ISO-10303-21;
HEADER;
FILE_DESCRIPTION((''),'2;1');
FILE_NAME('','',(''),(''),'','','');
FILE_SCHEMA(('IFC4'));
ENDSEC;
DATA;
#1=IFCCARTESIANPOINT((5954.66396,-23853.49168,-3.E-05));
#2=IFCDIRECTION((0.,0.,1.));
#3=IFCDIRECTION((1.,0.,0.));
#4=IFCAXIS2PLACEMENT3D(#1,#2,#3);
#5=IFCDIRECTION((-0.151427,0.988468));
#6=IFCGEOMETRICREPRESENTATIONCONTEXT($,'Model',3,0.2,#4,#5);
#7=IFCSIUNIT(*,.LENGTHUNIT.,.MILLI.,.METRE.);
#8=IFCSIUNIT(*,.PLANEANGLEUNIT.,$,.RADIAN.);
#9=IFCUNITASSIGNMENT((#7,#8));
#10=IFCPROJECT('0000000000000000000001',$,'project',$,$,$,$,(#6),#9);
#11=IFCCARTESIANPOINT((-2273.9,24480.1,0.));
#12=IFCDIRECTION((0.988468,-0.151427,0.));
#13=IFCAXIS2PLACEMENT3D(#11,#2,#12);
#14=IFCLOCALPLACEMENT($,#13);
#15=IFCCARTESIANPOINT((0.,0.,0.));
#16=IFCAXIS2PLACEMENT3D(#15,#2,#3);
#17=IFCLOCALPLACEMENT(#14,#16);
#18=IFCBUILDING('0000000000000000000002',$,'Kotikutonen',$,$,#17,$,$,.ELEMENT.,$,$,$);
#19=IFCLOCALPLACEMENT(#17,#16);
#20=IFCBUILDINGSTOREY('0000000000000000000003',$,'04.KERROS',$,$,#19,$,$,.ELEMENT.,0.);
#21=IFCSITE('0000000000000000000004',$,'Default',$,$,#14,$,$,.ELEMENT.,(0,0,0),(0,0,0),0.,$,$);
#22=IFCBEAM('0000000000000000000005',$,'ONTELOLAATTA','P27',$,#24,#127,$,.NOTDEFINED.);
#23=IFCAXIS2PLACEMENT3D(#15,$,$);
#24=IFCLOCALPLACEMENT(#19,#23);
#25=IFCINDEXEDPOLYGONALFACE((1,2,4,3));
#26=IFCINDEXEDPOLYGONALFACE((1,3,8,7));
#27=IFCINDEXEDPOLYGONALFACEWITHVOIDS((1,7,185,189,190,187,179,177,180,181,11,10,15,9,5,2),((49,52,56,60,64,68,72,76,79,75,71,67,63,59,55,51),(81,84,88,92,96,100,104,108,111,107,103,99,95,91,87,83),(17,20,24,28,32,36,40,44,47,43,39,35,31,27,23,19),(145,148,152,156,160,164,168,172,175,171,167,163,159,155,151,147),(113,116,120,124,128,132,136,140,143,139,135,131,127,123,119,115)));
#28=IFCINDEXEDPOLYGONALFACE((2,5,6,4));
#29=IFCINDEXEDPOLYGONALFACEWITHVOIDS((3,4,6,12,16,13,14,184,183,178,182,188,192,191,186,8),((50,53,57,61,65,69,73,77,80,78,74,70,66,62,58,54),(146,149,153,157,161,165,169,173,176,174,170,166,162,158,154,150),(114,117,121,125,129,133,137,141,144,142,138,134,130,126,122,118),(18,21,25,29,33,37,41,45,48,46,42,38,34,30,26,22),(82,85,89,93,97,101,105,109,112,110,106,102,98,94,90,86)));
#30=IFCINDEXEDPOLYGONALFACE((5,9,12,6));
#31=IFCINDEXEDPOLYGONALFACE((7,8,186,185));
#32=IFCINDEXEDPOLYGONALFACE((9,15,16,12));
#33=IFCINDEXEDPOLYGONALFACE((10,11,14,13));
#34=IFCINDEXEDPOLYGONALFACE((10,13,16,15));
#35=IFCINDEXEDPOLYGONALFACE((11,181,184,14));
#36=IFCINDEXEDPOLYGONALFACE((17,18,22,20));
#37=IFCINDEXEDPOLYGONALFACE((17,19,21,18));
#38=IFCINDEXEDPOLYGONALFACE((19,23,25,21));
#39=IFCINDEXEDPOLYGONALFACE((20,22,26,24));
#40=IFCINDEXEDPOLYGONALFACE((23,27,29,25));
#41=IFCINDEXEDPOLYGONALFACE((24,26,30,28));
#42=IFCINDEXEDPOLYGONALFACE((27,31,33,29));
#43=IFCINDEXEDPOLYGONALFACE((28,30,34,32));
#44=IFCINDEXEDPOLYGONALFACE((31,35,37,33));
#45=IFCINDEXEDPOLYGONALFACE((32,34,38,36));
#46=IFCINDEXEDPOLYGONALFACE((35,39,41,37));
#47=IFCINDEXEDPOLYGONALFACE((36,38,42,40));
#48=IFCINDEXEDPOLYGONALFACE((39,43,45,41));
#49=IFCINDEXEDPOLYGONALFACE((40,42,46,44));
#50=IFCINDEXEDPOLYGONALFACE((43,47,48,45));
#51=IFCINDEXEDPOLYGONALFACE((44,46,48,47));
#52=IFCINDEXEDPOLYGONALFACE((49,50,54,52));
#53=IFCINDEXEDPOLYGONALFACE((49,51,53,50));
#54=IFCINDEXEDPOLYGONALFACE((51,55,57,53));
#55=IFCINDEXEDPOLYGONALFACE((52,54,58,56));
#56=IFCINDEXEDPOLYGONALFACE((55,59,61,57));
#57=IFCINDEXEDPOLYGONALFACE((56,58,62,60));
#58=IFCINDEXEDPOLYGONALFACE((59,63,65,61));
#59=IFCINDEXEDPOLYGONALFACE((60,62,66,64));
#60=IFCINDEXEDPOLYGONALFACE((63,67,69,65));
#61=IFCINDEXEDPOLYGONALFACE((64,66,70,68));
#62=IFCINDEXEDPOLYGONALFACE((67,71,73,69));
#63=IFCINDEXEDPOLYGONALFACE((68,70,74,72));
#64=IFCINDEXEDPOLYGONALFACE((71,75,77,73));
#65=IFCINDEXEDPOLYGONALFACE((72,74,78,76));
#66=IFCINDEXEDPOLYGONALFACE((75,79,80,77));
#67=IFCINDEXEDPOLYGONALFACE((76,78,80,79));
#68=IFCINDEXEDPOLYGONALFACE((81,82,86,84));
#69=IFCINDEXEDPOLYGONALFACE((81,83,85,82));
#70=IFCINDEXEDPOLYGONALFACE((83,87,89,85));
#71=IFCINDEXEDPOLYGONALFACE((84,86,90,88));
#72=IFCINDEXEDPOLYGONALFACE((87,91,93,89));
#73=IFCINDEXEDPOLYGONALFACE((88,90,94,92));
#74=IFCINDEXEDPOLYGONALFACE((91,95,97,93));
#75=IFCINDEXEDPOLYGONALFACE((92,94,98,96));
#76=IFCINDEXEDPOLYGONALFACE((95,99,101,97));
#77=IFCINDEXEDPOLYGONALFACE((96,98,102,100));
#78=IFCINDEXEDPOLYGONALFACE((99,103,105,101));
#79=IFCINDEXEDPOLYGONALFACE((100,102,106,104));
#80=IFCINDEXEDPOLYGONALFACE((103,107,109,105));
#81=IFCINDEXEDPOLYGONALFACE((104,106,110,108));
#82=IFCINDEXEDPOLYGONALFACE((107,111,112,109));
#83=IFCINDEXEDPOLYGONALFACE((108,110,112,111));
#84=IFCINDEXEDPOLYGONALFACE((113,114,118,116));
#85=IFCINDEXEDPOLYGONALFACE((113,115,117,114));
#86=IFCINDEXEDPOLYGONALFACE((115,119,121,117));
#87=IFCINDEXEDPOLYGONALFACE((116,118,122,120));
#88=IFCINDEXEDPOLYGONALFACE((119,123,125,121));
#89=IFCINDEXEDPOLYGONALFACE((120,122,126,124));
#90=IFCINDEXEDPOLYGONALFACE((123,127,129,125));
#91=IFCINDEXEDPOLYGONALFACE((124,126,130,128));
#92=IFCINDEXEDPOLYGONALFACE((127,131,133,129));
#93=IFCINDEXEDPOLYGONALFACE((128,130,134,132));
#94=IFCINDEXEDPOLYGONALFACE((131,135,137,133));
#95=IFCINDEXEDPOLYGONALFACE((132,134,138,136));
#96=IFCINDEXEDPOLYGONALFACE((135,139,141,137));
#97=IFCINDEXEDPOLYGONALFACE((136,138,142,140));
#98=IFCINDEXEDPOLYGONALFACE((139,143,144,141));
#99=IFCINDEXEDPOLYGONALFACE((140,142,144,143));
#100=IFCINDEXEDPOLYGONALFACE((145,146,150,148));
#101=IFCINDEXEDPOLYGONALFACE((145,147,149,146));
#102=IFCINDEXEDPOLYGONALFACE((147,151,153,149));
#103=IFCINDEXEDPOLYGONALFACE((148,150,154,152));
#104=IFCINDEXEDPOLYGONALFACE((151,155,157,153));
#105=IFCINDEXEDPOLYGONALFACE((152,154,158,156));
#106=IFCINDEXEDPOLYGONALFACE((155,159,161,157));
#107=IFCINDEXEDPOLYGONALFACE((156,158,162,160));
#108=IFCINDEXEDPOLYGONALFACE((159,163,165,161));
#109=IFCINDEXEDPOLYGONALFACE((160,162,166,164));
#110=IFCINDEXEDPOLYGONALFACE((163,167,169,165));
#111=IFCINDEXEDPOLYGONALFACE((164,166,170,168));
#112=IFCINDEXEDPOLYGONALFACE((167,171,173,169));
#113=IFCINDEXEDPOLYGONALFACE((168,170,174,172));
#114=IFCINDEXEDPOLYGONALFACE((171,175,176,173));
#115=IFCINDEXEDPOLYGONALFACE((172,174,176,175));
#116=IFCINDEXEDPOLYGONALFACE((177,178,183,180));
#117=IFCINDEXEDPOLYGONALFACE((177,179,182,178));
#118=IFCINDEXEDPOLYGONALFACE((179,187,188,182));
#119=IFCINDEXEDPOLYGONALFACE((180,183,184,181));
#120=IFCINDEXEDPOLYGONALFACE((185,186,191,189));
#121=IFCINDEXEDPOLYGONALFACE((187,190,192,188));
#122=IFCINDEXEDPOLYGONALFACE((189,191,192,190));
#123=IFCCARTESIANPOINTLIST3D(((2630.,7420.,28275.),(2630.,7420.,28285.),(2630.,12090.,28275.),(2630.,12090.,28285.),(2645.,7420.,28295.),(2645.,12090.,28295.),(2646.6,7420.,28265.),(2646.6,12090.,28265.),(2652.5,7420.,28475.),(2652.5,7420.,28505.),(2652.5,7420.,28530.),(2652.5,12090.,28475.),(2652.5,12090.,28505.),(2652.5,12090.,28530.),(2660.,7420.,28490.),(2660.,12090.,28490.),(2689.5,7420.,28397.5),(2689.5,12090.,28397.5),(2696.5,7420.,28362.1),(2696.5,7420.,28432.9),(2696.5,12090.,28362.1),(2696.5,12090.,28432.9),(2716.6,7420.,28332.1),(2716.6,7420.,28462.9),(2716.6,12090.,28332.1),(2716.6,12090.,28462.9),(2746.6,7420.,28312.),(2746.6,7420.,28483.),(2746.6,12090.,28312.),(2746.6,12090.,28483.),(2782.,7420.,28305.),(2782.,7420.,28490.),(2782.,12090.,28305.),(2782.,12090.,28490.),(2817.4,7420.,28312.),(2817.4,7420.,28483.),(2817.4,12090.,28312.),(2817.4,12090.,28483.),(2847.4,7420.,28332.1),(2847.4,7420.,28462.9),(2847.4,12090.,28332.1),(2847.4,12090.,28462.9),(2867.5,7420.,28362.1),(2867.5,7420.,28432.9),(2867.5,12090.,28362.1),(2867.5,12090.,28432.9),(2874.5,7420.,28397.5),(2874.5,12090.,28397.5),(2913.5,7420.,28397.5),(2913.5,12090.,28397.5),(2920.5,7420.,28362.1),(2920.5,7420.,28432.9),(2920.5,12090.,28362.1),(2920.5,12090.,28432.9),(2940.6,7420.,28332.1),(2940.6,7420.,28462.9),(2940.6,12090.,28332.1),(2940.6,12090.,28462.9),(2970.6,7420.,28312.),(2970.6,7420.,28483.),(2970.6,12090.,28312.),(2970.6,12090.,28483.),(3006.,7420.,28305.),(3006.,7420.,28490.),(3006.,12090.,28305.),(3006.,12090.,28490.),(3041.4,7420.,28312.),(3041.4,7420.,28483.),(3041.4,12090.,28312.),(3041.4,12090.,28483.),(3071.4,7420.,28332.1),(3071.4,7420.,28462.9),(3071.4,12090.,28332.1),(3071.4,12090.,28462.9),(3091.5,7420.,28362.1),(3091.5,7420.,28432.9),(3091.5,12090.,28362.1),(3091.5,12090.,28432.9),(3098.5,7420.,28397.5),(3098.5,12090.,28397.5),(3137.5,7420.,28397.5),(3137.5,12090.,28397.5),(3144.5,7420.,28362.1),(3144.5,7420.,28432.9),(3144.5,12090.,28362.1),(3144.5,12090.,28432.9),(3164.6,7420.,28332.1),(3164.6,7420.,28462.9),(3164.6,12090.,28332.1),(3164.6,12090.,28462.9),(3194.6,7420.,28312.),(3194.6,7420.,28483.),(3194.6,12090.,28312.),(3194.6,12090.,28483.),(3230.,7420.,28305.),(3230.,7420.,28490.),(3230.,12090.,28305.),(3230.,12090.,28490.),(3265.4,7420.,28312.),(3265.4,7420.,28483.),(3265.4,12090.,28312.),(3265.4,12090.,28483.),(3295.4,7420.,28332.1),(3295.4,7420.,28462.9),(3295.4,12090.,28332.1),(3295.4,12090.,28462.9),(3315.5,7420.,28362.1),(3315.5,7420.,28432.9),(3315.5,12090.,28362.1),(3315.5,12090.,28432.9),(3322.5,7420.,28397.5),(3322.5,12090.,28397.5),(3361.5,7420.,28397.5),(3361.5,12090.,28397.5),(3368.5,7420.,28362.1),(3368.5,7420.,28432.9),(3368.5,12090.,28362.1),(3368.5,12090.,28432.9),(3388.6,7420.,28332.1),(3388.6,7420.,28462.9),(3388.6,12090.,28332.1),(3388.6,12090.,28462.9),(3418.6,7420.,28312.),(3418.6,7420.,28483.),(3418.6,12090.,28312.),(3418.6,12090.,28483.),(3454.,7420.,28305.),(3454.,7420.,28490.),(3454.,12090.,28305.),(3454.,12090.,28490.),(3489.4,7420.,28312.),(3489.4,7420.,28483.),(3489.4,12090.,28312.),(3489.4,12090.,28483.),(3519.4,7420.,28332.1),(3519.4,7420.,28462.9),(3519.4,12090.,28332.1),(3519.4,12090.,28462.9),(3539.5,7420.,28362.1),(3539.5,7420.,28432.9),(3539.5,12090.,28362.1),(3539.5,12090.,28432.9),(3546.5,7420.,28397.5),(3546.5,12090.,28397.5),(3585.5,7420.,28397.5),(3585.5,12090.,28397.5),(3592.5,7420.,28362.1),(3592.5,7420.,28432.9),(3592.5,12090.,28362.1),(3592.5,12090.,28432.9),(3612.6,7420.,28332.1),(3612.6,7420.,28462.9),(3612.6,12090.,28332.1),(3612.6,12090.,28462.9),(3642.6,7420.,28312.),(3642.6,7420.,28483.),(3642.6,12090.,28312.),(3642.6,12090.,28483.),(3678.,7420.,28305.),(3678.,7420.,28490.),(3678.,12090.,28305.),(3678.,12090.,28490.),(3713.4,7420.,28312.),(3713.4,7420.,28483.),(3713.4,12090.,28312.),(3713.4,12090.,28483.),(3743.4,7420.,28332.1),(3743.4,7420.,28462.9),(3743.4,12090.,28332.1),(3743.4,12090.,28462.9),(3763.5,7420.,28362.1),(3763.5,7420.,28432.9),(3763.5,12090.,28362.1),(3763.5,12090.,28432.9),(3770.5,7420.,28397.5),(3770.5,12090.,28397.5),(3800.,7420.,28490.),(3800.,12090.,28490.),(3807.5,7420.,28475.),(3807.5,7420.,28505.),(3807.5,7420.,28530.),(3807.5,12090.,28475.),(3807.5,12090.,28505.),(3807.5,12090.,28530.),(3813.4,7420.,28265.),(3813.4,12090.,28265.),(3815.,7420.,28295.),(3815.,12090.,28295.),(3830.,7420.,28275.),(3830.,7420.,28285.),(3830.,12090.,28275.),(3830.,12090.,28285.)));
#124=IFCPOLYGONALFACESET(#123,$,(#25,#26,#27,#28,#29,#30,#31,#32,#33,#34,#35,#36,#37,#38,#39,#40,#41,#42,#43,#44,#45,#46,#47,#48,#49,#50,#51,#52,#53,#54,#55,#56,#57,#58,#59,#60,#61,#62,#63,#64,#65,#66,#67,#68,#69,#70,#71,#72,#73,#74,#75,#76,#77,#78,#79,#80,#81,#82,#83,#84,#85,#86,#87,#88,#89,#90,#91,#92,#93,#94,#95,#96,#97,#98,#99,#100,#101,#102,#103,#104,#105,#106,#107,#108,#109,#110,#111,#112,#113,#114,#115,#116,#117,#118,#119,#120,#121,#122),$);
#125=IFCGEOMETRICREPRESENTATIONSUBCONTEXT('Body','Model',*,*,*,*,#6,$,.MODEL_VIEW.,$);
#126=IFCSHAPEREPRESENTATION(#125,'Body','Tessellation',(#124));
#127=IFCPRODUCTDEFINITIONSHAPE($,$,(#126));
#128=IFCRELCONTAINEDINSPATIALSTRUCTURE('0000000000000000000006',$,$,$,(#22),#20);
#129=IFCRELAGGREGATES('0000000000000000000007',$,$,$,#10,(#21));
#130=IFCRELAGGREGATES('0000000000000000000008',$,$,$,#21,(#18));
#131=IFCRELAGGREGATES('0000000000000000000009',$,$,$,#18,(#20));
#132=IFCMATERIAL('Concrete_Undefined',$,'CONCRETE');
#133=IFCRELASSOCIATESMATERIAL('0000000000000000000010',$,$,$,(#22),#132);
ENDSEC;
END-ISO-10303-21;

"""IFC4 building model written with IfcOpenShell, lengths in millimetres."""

from ifc_helpers import new_model, si_unit, direction, frame, origin_with_axes, place, context, subcontext, project, spatial, line, indexed_curve, outline, extrude, material, element, save


model = new_model("IFC4")

# Units and contexts
model_context = context("Model", 3, precision=0.2, world=frame((5954.66396, -23853.49168, -3e-05), z_axis=(0.0, 0.0, 1.0), x_axis=(1.0, 0.0, 0.0)), true_north=direction((-0.151427, 0.988468)))
body_context = subcontext(model_context, "Body", "Model", "MODEL_VIEW")
ifc_project = project(units=[si_unit("LENGTHUNIT", "METRE", prefix="MILLI"), si_unit("PLANEANGLEUNIT", "RADIAN")], contexts=[model_context])

# Site, building, storey
site_placement = place(None, frame((-2273.9, 24480.1, 0.0), z_axis=(0.0, 0.0, 1.0), x_axis=(0.988468, -0.151427, 0.0)))
site = spatial("IfcSite", under=ifc_project, at=site_placement, Name="Default", CompositionType="ELEMENT", RefLatitude=(0, 0, 0), RefLongitude=(0, 0, 0), RefElevation=0.0)
building_placement = place(site_placement, origin_with_axes())
building = spatial("IfcBuilding", under=site, at=building_placement, Name="Kotikutonen", CompositionType="ELEMENT")
storey_placement = place(building_placement, origin_with_axes())
storey = spatial("IfcBuildingStorey", under=building, at=storey_placement, Name="04.KERROS", CompositionType="ELEMENT", Elevation=0.0)

# Beam
ifc_material_1 = material(Name="Concrete_Undefined", Category="CONCRETE")
beam_1_placement = place(storey_placement, frame((3230.0, 12090.0, 28397.5), z_axis=(-1.0, 0.0, 0.0), x_axis=(0.0, -1.0, 0.0)))
element("IfcBeam", 1, at=beam_1_placement, inside=storey, material=ifc_material_1, Name="ONTELOLAATTA", Description="P27", PredefinedType="NOTDEFINED", context=body_context, shape_type="SolidModel", body=[
    extrude(outline(indexed_curve([(-600.0, -122.5), (-583.4, -132.5), (583.4, -132.5), (600.0, -122.5), (600.0, -112.5), (585.0, -102.5), (577.5, 77.5), (570.0, 92.5), (577.5, 107.5), (577.5, 132.5), (-577.5, 132.5), (-577.5, 107.5), (-570.0, 92.5), (-577.5, 77.5), (-585.0, -102.5), (-600.0, -112.5)], segments=[line(1, 2, 3, 4, 5, 6, 7, 8, 9, 10, 11, 12, 13, 14, 15, 16, 1)]), holes=[indexed_curve([(-448.0, -92.5), (-483.4, -85.5), (-513.4, -65.4), (-533.5, -35.4), (-540.5, 0.0), (-533.5, 35.4), (-513.4, 65.4), (-483.4, 85.5), (-448.0, 92.5), (-412.6, 85.5), (-382.6, 65.4), (-362.5, 35.4), (-355.5, 0.0), (-362.5, -35.4), (-382.6, -65.4), (-412.6, -85.5)], segments=[line(1, 2, 3, 4, 5, 6, 7, 8, 9, 10, 11, 12, 13, 14, 15, 16, 1)]), indexed_curve([(-224.0, -92.5), (-259.4, -85.5), (-289.4, -65.4), (-309.5, -35.4), (-316.5, 0.0), (-309.5, 35.4), (-289.4, 65.4), (-259.4, 85.5), (-224.0, 92.5), (-188.6, 85.5), (-158.6, 65.4), (-138.5, 35.4), (-131.5, 0.0), (-138.5, -35.4), (-158.6, -65.4), (-188.6, -85.5)], segments=[line(1, 2, 3, 4, 5, 6, 7, 8, 9, 10, 11, 12, 13, 14, 15, 16, 1)]), indexed_curve([(0.0, -92.5), (-35.4, -85.5), (-65.4, -65.4), (-85.5, -35.4), (-92.5, 0.0), (-85.5, 35.4), (-65.4, 65.4), (-35.4, 85.5), (0.0, 92.5), (35.4, 85.5), (65.4, 65.4), (85.5, 35.4), (92.5, 0.0), (85.5, -35.4), (65.4, -65.4), (35.4, -85.5)], segments=[line(1, 2, 3, 4, 5, 6, 7, 8, 9, 10, 11, 12, 13, 14, 15, 16, 1)]), indexed_curve([(224.0, -92.5), (188.6, -85.5), (158.6, -65.4), (138.5, -35.4), (131.5, 0.0), (138.5, 35.4), (158.6, 65.4), (188.6, 85.5), (224.0, 92.5), (259.4, 85.5), (289.4, 65.4), (309.5, 35.4), (316.5, 0.0), (309.5, -35.4), (289.4, -65.4), (259.4, -85.5)], segments=[line(1, 2, 3, 4, 5, 6, 7, 8, 9, 10, 11, 12, 13, 14, 15, 16, 1)]), indexed_curve([(448.0, -92.5), (412.6, -85.5), (382.6, -65.4), (362.5, -35.4), (355.5, 0.0), (362.5, 35.4), (382.6, 65.4), (412.6, 85.5), (448.0, 92.5), (483.4, 85.5), (513.4, 65.4), (533.5, 35.4), (540.5, 0.0), (533.5, -35.4), (513.4, -65.4), (483.4, -85.5)], segments=[line(1, 2, 3, 4, 5, 6, 7, 8, 9, 10, 11, 12, 13, 14, 15, 16, 1)])]), frame((0.0, 0.0, 0.0), z_axis=(-1.0, 0.0, 0.0), x_axis=(0.0, 0.0, 1.0)), (0.0, 0.0, -1.0), 4670.0),
])

save(model, "model.ifc")
